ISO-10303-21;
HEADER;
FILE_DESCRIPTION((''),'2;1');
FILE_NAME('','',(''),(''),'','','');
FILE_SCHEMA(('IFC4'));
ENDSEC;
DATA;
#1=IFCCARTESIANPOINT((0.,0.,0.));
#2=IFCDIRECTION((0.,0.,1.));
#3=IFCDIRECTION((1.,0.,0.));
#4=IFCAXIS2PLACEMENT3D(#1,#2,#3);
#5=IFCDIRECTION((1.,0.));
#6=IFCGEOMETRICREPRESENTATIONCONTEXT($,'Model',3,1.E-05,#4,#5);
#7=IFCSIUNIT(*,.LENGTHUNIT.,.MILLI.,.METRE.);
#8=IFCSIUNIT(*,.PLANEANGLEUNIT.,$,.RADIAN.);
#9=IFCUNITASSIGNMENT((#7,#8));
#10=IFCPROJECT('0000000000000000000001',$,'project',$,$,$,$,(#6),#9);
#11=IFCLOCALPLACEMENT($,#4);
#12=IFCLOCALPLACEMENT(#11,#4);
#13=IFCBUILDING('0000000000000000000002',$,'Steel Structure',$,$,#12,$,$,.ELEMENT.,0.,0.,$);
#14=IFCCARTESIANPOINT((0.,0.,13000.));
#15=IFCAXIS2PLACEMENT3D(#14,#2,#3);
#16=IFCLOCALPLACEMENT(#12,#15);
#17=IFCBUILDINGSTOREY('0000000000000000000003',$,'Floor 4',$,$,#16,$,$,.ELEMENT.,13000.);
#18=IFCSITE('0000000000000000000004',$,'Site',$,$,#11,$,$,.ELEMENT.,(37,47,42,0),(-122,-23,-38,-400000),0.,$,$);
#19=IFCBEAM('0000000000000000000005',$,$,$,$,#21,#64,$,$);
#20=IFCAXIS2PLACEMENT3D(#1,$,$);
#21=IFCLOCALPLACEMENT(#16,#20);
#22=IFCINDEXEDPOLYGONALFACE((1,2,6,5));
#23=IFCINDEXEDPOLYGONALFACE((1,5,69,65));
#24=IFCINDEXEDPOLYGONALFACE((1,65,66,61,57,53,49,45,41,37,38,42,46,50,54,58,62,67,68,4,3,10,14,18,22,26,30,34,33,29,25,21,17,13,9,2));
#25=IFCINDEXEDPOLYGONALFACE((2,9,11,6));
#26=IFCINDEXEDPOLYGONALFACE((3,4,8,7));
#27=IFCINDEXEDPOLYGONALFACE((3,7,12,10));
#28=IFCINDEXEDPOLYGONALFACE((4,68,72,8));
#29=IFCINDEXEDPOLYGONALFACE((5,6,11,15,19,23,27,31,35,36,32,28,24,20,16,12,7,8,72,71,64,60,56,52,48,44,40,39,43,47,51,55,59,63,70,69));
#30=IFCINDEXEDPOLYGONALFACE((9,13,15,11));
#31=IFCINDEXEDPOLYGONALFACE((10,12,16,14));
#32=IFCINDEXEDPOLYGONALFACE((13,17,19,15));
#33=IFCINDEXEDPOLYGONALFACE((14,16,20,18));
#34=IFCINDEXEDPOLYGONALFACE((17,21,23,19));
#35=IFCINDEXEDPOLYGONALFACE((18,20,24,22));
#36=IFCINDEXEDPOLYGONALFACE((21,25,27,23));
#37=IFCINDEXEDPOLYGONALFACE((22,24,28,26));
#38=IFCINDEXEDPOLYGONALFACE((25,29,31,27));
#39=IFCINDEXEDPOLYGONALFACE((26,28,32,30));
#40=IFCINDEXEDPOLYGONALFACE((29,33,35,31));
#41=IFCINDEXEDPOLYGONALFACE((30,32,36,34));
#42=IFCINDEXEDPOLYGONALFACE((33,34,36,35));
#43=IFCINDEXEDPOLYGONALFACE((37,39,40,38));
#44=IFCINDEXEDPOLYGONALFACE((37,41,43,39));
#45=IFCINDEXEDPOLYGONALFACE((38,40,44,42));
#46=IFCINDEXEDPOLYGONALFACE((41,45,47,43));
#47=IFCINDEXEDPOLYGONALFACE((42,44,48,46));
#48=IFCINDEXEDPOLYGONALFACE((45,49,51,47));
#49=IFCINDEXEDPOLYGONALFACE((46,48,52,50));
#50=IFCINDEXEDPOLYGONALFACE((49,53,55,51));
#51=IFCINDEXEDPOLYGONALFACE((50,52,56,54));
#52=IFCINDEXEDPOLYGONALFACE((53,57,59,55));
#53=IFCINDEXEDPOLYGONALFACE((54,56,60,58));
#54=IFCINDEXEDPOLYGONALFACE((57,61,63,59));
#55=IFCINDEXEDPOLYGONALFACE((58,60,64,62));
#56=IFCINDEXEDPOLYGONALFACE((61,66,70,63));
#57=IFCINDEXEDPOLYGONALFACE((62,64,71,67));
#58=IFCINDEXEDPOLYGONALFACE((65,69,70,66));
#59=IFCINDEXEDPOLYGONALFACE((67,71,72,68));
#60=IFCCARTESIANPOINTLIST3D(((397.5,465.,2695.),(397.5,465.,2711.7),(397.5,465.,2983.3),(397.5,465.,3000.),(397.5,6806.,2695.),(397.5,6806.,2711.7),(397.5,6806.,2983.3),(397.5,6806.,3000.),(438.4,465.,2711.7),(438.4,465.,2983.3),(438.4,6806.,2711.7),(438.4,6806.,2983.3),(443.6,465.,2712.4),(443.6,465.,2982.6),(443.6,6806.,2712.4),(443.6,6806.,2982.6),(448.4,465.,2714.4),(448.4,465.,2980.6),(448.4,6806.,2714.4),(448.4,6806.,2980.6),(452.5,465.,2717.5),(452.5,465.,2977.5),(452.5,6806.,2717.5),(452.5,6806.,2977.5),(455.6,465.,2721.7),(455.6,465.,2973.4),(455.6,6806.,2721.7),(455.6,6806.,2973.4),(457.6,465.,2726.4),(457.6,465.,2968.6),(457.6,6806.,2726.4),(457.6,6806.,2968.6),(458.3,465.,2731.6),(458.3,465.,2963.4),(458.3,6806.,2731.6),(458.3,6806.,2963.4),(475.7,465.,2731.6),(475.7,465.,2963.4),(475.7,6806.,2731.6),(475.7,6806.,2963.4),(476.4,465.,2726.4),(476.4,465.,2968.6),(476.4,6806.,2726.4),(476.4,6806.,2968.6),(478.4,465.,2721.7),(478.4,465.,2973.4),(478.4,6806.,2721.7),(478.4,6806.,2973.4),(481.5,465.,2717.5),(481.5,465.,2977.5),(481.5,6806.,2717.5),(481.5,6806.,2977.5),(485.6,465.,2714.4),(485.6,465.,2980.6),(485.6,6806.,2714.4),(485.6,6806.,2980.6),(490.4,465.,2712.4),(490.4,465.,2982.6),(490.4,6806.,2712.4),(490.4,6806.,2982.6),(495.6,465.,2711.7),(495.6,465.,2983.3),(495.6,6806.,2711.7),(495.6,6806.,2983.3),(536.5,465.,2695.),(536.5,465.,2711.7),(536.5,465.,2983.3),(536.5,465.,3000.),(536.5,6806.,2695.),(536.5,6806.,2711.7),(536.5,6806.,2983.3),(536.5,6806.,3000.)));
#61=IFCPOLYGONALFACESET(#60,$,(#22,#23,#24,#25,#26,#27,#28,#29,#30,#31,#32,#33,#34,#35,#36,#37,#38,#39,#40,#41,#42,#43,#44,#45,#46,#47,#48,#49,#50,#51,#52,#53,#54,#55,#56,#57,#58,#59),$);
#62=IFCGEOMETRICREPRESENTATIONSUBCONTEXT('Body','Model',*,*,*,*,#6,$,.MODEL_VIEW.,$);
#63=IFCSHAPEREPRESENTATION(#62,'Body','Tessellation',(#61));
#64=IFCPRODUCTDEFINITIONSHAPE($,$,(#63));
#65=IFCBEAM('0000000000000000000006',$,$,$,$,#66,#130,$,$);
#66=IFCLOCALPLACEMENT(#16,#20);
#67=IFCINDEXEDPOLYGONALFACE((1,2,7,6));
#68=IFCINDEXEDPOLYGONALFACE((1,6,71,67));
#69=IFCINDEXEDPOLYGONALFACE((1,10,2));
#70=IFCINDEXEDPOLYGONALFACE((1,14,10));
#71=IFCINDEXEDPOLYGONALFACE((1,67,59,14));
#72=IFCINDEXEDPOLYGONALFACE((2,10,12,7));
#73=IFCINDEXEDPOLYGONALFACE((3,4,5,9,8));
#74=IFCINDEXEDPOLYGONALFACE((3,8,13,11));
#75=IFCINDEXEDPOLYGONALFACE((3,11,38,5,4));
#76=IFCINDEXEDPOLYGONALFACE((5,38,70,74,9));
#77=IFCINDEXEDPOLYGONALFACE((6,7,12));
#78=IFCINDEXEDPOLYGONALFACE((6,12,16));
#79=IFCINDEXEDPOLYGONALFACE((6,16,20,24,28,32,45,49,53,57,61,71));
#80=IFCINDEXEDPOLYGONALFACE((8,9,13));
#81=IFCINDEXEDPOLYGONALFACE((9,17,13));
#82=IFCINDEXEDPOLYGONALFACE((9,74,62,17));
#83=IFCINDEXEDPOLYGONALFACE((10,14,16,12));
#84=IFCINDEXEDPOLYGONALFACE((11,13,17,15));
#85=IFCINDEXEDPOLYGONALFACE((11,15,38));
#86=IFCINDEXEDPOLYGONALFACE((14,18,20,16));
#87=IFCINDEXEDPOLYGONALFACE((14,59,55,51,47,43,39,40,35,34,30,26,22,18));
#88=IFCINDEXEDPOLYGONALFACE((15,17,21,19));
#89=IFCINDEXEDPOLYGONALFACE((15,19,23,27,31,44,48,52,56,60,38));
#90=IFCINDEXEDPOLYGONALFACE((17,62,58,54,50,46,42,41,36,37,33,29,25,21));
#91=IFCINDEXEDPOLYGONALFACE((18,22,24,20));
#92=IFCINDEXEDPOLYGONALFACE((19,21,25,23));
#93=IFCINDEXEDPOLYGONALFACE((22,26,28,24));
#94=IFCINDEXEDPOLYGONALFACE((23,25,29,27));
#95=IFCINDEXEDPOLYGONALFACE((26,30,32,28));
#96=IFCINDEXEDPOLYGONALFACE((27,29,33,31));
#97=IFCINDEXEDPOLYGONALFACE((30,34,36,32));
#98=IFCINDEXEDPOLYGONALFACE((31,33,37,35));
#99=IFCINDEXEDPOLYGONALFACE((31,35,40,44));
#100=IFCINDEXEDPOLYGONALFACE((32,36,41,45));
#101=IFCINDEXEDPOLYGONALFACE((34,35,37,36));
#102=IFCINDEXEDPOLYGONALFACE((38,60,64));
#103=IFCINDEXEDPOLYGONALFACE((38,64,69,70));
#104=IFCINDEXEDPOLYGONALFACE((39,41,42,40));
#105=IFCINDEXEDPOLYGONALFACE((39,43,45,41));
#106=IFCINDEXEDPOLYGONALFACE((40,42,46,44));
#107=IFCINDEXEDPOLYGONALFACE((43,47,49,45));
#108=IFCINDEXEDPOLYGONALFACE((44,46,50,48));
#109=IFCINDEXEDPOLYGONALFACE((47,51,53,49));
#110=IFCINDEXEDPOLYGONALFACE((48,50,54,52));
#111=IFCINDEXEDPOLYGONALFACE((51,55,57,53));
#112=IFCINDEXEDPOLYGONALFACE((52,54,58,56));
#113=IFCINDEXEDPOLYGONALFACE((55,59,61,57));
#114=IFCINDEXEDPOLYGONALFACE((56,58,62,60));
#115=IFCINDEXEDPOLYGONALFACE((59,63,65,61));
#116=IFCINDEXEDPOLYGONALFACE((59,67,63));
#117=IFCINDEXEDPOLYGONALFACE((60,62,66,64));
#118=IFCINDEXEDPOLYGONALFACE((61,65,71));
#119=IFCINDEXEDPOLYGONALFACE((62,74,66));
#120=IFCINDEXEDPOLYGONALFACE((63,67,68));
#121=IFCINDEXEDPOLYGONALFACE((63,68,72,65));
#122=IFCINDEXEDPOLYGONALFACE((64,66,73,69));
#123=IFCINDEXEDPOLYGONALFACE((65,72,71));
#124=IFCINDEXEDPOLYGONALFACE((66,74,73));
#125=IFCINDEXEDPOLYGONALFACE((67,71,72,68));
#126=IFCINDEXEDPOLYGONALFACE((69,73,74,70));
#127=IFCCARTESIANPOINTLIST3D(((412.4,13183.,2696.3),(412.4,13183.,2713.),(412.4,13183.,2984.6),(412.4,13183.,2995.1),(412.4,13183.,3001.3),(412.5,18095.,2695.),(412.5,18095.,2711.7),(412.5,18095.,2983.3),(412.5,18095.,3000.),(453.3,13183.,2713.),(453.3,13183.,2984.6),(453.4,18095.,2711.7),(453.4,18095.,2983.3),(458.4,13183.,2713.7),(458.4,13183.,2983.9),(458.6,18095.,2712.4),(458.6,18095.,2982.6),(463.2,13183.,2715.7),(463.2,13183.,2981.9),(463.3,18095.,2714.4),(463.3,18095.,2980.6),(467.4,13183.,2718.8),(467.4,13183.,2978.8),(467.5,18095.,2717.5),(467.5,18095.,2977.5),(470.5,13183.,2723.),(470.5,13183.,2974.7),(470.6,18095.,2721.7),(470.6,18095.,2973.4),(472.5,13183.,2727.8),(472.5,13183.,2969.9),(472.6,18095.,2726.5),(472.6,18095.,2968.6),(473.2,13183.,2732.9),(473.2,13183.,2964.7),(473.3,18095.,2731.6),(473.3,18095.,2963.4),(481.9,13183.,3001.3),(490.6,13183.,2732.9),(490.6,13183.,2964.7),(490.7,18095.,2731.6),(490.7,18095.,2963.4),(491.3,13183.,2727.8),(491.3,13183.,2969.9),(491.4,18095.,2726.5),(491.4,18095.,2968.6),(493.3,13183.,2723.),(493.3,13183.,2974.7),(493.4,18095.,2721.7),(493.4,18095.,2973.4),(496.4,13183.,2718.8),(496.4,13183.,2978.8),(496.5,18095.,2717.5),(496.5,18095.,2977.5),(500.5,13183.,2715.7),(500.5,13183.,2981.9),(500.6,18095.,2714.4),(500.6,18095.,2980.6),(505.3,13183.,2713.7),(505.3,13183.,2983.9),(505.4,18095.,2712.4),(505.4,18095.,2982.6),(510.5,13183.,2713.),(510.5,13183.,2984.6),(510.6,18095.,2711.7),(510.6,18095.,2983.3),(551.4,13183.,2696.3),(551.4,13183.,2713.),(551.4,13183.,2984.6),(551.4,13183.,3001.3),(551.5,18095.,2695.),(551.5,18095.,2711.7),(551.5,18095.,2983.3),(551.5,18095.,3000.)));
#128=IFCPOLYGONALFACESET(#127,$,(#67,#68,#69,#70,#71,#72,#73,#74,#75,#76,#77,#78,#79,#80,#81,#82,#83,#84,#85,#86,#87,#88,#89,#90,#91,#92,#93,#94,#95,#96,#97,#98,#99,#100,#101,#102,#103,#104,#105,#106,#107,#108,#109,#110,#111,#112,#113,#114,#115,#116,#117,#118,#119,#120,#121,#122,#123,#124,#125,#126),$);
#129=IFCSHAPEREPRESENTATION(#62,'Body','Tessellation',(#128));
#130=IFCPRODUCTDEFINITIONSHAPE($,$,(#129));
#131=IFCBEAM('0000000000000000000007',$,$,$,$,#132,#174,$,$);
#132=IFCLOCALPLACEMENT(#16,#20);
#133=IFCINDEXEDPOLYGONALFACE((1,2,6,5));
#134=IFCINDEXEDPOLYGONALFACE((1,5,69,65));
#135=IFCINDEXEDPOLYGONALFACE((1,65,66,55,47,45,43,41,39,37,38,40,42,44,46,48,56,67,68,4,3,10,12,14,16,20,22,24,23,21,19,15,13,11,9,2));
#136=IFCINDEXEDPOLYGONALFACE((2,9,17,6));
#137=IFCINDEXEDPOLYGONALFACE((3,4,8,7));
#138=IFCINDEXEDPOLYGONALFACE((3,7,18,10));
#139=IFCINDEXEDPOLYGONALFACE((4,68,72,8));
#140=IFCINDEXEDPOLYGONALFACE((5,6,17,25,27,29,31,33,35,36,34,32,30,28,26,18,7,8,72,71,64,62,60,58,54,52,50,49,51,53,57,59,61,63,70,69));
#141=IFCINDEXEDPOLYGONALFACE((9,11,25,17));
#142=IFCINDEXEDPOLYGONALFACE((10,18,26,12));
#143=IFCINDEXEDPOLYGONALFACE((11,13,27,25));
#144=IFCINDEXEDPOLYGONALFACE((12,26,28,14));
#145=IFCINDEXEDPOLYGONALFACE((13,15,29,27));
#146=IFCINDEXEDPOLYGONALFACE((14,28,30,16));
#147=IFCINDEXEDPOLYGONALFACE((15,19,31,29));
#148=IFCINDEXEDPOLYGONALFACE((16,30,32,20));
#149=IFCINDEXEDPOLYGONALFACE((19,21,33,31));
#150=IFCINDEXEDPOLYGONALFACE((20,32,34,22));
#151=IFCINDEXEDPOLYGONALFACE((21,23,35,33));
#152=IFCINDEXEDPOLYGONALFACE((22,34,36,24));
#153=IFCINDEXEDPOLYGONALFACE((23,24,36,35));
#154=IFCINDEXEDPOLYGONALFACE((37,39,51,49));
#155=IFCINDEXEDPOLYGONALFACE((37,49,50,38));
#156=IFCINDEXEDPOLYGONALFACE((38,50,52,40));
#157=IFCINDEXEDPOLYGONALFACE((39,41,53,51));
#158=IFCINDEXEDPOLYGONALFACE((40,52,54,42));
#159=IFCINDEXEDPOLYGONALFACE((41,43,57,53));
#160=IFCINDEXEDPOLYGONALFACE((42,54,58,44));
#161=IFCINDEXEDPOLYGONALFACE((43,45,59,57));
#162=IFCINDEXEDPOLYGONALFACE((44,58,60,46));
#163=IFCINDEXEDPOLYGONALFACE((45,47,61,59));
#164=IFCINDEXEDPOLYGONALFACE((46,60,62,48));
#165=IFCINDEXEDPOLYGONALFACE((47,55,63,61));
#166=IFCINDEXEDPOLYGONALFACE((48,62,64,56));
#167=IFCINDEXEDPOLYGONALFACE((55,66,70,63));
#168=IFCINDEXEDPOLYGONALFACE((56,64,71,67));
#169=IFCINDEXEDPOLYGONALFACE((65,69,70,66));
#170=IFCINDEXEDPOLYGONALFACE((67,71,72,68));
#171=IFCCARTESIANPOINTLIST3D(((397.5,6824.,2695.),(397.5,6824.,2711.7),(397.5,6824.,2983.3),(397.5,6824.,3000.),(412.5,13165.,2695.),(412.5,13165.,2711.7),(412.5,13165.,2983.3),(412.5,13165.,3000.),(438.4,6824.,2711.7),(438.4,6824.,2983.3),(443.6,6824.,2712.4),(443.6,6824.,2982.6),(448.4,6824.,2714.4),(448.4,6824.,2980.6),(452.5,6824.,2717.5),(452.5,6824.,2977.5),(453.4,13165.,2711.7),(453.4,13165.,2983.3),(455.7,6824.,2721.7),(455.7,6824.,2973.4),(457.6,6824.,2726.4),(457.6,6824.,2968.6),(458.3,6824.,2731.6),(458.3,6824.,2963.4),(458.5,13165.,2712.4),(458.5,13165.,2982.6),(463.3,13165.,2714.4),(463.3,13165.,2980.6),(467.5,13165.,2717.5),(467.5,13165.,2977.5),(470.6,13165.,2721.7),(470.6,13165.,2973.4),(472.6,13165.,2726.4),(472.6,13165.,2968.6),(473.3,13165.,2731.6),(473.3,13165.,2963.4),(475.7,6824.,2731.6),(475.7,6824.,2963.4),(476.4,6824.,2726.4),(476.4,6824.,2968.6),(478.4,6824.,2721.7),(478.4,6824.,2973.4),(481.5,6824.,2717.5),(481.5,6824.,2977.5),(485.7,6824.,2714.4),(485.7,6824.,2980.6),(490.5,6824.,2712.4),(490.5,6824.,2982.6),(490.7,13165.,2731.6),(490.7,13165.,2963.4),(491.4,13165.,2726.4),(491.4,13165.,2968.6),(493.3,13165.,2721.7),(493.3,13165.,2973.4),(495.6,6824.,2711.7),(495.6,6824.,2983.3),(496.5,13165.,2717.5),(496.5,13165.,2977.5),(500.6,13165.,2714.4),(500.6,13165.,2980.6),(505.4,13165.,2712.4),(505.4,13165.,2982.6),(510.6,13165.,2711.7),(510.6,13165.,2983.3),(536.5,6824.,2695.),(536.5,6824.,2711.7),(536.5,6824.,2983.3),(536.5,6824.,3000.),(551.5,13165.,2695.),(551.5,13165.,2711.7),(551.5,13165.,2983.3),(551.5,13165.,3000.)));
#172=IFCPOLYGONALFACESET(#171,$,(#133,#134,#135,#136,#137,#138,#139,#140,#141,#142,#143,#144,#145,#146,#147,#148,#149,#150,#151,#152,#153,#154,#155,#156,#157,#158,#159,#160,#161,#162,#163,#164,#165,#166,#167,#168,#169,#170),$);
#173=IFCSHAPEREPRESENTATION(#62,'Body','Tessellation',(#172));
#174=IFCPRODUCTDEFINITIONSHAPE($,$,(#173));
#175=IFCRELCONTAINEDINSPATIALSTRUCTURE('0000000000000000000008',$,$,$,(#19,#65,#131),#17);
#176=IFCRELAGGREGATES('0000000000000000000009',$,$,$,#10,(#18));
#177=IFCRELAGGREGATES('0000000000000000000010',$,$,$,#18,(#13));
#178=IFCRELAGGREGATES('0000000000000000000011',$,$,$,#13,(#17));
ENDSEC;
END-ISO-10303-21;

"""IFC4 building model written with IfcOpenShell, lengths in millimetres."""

from ifc_helpers import new_model, si_unit, direction, frame, origin_with_axes, origin_2d_with_axis, place, context, subcontext, project, spatial, polyline, i_section, extrude, clip, bounded_halfspace, element, save


model = new_model("IFC4")

# Units and contexts
model_context = context("Model", 3, precision=1e-05, world=origin_with_axes(), true_north=direction((1.0, 0.0)))
body_context = subcontext(model_context, "Body", "Model", "MODEL_VIEW")
ifc_project = project(units=[si_unit("LENGTHUNIT", "METRE", prefix="MILLI"), si_unit("PLANEANGLEUNIT", "RADIAN")], contexts=[model_context])

# Site, building, storey
site_placement = place(None, origin_with_axes())
site = spatial("IfcSite", under=ifc_project, at=site_placement, Name="Site", CompositionType="ELEMENT", RefLatitude=(37, 47, 42, 0), RefLongitude=(-122, -23, -38, -400000), RefElevation=0.0)
building_placement = place(site_placement, origin_with_axes())
building = spatial("IfcBuilding", under=site, at=building_placement, Name="Steel Structure", CompositionType="ELEMENT", ElevationOfRefHeight=0.0, ElevationOfTerrain=0.0)
storey_placement = place(building_placement, frame((0.0, 0.0, 13000.0), z_axis=(0.0, 0.0, 1.0), x_axis=(1.0, 0.0, 0.0)))
storey = spatial("IfcBuildingStorey", under=building, at=storey_placement, Name="Floor 4", CompositionType="ELEMENT", Elevation=13000.0)

# Beams
beam_1_placement = place(storey_placement, frame((467.0, 6806.0, 2695.0), z_axis=(0.0, -1.0, 0.0), x_axis=(1.0, 0.0, 0.0)))
element("IfcBeam", 1, at=beam_1_placement, inside=storey, context=body_context, shape_type="SweptSolid", body=[
    extrude(i_section(OverallWidth=139.0, OverallDepth=305.0, WebThickness=17.4, FlangeThickness=16.7, FilletRadius=19.9, at=origin_2d_with_axis()), frame((0.0, 152.5, 0.0), z_axis=(0.0, 0.0, 1.0), x_axis=(1.0, 0.0, 0.0)), (0.0, 0.0, 1.0), 6341.0),
])
beam_2_placement = place(storey_placement, frame((482.0, 18095.0, 2695.0), z_axis=(-0.000023, -1.0, 0.000265), x_axis=(1.0, -0.000023, 0.0)))
element("IfcBeam", 2, at=beam_2_placement, inside=storey, context=body_context, shape_type="Clipping", body=[
    clip(clip(extrude(i_section(OverallWidth=139.0, OverallDepth=305.0, WebThickness=17.4, FlangeThickness=16.7, FilletRadius=19.9, at=origin_2d_with_axis()), frame((0.0, 152.5, 0.0), z_axis=(0.0, 0.0, 1.0), x_axis=(1.0, 0.0, 0.0)), (0.0, 0.0, 1.0), 4912.1), bounded_halfspace(frame((-482.0, -15695.0, -4.1), z_axis=(-0.000023, 0.000265, -1.0), x_axis=(-1.0, 0.0, 0.000023)), False, frame((0.0, 152.5, 0.0), z_axis=(0.0, 0.0, 1.0), x_axis=(1.0, 0.0, 0.0)), polyline([(69.5, 152.5), (69.5, 135.8), (28.6, 135.8), (8.7, 115.9), (8.7, -115.9), (28.6, -135.8), (69.5, -135.8), (69.5, -152.5), (-69.5, -152.5), (-69.5, -135.8), (-28.6, -135.8), (-8.7, -115.9), (-8.7, 115.9), (-28.6, 135.8), (-69.5, 135.8), (-69.5, 152.5), (69.5, 152.5)]))), bounded_halfspace(frame((-481.9, -15696.3, 4907.9), z_axis=(0.000023, -0.000265, 1.0), x_axis=(1.0, 0.0, -0.000023)), False, frame((0.0, 152.5, 0.0), z_axis=(0.0, 0.0, 1.0), x_axis=(1.0, 0.0, 0.0)), polyline([(-69.5, -135.8), (-69.5, -152.5), (69.5, -152.5), (69.5, -135.8), (28.6, -135.8), (8.7, -115.9), (8.7, 115.9), (28.6, 135.8), (69.5, 135.8), (69.5, 152.5), (0.0, 152.5), (-69.5, 146.3), (-69.5, 135.8), (-28.6, 135.8), (-8.7, 115.9), (-8.7, -115.9), (-28.6, -135.8), (-69.5, -135.8)]))),
])
beam_3_placement = place(storey_placement, frame((467.0, 6823.8, 2695.0), z_axis=(0.002359, 0.999997, 0.0), x_axis=(-0.999997, 0.002359, 0.0)))
element("IfcBeam", 3, at=beam_3_placement, inside=storey, context=body_context, shape_type="Clipping", body=[
    clip(clip(extrude(i_section(OverallWidth=139.0, OverallDepth=305.0, WebThickness=17.4, FlangeThickness=16.7, FilletRadius=19.9, at=origin_2d_with_axis()), frame((0.0, 152.5, 0.0), z_axis=(0.0, 0.0, 1.0), x_axis=(1.0, 0.0, 0.0)), (0.0, 0.0, 1.0), 6341.3), bounded_halfspace(frame((482.0, -15695.0, 6340.0), z_axis=(0.002359, 0.0, 0.999997), x_axis=(0.999997, 0.0, -0.002359)), False, frame((0.0, 152.5, 0.0), z_axis=(0.0, 0.0, 1.0), x_axis=(1.0, 0.0, 0.0)), polyline([(69.5, 135.8), (69.5, 152.5), (-69.5, 152.5), (-69.5, 135.8), (-28.6, 135.8), (-8.7, 115.9), (-8.7, -115.9), (-28.6, -135.8), (-69.5, -135.8), (-69.5, -152.5), (69.5, -152.5), (69.5, -135.8), (28.6, -135.8), (8.7, -115.9), (8.7, 115.9), (28.6, 135.8), (69.5, 135.8)]))), bounded_halfspace(frame((467.0, -15695.0, -0.9), z_axis=(-0.002359, 0.0, -0.999997), x_axis=(-0.999997, 0.0, 0.002359)), False, frame((0.0, 152.5, 0.0), z_axis=(0.0, 0.0, 1.0), x_axis=(1.0, 0.0, 0.0)), polyline([(-69.5, -152.5), (-69.5, -135.8), (-28.6, -135.8), (-8.7, -115.9), (-8.7, 115.9), (-28.6, 135.8), (-69.5, 135.8), (-69.5, 152.5), (69.5, 152.5), (69.5, 135.8), (28.6, 135.8), (8.7, 115.9), (8.7, -115.9), (28.6, -135.8), (69.5, -135.8), (69.5, -152.5), (-69.5, -152.5)]))),
])

save(model, "model.ifc")
